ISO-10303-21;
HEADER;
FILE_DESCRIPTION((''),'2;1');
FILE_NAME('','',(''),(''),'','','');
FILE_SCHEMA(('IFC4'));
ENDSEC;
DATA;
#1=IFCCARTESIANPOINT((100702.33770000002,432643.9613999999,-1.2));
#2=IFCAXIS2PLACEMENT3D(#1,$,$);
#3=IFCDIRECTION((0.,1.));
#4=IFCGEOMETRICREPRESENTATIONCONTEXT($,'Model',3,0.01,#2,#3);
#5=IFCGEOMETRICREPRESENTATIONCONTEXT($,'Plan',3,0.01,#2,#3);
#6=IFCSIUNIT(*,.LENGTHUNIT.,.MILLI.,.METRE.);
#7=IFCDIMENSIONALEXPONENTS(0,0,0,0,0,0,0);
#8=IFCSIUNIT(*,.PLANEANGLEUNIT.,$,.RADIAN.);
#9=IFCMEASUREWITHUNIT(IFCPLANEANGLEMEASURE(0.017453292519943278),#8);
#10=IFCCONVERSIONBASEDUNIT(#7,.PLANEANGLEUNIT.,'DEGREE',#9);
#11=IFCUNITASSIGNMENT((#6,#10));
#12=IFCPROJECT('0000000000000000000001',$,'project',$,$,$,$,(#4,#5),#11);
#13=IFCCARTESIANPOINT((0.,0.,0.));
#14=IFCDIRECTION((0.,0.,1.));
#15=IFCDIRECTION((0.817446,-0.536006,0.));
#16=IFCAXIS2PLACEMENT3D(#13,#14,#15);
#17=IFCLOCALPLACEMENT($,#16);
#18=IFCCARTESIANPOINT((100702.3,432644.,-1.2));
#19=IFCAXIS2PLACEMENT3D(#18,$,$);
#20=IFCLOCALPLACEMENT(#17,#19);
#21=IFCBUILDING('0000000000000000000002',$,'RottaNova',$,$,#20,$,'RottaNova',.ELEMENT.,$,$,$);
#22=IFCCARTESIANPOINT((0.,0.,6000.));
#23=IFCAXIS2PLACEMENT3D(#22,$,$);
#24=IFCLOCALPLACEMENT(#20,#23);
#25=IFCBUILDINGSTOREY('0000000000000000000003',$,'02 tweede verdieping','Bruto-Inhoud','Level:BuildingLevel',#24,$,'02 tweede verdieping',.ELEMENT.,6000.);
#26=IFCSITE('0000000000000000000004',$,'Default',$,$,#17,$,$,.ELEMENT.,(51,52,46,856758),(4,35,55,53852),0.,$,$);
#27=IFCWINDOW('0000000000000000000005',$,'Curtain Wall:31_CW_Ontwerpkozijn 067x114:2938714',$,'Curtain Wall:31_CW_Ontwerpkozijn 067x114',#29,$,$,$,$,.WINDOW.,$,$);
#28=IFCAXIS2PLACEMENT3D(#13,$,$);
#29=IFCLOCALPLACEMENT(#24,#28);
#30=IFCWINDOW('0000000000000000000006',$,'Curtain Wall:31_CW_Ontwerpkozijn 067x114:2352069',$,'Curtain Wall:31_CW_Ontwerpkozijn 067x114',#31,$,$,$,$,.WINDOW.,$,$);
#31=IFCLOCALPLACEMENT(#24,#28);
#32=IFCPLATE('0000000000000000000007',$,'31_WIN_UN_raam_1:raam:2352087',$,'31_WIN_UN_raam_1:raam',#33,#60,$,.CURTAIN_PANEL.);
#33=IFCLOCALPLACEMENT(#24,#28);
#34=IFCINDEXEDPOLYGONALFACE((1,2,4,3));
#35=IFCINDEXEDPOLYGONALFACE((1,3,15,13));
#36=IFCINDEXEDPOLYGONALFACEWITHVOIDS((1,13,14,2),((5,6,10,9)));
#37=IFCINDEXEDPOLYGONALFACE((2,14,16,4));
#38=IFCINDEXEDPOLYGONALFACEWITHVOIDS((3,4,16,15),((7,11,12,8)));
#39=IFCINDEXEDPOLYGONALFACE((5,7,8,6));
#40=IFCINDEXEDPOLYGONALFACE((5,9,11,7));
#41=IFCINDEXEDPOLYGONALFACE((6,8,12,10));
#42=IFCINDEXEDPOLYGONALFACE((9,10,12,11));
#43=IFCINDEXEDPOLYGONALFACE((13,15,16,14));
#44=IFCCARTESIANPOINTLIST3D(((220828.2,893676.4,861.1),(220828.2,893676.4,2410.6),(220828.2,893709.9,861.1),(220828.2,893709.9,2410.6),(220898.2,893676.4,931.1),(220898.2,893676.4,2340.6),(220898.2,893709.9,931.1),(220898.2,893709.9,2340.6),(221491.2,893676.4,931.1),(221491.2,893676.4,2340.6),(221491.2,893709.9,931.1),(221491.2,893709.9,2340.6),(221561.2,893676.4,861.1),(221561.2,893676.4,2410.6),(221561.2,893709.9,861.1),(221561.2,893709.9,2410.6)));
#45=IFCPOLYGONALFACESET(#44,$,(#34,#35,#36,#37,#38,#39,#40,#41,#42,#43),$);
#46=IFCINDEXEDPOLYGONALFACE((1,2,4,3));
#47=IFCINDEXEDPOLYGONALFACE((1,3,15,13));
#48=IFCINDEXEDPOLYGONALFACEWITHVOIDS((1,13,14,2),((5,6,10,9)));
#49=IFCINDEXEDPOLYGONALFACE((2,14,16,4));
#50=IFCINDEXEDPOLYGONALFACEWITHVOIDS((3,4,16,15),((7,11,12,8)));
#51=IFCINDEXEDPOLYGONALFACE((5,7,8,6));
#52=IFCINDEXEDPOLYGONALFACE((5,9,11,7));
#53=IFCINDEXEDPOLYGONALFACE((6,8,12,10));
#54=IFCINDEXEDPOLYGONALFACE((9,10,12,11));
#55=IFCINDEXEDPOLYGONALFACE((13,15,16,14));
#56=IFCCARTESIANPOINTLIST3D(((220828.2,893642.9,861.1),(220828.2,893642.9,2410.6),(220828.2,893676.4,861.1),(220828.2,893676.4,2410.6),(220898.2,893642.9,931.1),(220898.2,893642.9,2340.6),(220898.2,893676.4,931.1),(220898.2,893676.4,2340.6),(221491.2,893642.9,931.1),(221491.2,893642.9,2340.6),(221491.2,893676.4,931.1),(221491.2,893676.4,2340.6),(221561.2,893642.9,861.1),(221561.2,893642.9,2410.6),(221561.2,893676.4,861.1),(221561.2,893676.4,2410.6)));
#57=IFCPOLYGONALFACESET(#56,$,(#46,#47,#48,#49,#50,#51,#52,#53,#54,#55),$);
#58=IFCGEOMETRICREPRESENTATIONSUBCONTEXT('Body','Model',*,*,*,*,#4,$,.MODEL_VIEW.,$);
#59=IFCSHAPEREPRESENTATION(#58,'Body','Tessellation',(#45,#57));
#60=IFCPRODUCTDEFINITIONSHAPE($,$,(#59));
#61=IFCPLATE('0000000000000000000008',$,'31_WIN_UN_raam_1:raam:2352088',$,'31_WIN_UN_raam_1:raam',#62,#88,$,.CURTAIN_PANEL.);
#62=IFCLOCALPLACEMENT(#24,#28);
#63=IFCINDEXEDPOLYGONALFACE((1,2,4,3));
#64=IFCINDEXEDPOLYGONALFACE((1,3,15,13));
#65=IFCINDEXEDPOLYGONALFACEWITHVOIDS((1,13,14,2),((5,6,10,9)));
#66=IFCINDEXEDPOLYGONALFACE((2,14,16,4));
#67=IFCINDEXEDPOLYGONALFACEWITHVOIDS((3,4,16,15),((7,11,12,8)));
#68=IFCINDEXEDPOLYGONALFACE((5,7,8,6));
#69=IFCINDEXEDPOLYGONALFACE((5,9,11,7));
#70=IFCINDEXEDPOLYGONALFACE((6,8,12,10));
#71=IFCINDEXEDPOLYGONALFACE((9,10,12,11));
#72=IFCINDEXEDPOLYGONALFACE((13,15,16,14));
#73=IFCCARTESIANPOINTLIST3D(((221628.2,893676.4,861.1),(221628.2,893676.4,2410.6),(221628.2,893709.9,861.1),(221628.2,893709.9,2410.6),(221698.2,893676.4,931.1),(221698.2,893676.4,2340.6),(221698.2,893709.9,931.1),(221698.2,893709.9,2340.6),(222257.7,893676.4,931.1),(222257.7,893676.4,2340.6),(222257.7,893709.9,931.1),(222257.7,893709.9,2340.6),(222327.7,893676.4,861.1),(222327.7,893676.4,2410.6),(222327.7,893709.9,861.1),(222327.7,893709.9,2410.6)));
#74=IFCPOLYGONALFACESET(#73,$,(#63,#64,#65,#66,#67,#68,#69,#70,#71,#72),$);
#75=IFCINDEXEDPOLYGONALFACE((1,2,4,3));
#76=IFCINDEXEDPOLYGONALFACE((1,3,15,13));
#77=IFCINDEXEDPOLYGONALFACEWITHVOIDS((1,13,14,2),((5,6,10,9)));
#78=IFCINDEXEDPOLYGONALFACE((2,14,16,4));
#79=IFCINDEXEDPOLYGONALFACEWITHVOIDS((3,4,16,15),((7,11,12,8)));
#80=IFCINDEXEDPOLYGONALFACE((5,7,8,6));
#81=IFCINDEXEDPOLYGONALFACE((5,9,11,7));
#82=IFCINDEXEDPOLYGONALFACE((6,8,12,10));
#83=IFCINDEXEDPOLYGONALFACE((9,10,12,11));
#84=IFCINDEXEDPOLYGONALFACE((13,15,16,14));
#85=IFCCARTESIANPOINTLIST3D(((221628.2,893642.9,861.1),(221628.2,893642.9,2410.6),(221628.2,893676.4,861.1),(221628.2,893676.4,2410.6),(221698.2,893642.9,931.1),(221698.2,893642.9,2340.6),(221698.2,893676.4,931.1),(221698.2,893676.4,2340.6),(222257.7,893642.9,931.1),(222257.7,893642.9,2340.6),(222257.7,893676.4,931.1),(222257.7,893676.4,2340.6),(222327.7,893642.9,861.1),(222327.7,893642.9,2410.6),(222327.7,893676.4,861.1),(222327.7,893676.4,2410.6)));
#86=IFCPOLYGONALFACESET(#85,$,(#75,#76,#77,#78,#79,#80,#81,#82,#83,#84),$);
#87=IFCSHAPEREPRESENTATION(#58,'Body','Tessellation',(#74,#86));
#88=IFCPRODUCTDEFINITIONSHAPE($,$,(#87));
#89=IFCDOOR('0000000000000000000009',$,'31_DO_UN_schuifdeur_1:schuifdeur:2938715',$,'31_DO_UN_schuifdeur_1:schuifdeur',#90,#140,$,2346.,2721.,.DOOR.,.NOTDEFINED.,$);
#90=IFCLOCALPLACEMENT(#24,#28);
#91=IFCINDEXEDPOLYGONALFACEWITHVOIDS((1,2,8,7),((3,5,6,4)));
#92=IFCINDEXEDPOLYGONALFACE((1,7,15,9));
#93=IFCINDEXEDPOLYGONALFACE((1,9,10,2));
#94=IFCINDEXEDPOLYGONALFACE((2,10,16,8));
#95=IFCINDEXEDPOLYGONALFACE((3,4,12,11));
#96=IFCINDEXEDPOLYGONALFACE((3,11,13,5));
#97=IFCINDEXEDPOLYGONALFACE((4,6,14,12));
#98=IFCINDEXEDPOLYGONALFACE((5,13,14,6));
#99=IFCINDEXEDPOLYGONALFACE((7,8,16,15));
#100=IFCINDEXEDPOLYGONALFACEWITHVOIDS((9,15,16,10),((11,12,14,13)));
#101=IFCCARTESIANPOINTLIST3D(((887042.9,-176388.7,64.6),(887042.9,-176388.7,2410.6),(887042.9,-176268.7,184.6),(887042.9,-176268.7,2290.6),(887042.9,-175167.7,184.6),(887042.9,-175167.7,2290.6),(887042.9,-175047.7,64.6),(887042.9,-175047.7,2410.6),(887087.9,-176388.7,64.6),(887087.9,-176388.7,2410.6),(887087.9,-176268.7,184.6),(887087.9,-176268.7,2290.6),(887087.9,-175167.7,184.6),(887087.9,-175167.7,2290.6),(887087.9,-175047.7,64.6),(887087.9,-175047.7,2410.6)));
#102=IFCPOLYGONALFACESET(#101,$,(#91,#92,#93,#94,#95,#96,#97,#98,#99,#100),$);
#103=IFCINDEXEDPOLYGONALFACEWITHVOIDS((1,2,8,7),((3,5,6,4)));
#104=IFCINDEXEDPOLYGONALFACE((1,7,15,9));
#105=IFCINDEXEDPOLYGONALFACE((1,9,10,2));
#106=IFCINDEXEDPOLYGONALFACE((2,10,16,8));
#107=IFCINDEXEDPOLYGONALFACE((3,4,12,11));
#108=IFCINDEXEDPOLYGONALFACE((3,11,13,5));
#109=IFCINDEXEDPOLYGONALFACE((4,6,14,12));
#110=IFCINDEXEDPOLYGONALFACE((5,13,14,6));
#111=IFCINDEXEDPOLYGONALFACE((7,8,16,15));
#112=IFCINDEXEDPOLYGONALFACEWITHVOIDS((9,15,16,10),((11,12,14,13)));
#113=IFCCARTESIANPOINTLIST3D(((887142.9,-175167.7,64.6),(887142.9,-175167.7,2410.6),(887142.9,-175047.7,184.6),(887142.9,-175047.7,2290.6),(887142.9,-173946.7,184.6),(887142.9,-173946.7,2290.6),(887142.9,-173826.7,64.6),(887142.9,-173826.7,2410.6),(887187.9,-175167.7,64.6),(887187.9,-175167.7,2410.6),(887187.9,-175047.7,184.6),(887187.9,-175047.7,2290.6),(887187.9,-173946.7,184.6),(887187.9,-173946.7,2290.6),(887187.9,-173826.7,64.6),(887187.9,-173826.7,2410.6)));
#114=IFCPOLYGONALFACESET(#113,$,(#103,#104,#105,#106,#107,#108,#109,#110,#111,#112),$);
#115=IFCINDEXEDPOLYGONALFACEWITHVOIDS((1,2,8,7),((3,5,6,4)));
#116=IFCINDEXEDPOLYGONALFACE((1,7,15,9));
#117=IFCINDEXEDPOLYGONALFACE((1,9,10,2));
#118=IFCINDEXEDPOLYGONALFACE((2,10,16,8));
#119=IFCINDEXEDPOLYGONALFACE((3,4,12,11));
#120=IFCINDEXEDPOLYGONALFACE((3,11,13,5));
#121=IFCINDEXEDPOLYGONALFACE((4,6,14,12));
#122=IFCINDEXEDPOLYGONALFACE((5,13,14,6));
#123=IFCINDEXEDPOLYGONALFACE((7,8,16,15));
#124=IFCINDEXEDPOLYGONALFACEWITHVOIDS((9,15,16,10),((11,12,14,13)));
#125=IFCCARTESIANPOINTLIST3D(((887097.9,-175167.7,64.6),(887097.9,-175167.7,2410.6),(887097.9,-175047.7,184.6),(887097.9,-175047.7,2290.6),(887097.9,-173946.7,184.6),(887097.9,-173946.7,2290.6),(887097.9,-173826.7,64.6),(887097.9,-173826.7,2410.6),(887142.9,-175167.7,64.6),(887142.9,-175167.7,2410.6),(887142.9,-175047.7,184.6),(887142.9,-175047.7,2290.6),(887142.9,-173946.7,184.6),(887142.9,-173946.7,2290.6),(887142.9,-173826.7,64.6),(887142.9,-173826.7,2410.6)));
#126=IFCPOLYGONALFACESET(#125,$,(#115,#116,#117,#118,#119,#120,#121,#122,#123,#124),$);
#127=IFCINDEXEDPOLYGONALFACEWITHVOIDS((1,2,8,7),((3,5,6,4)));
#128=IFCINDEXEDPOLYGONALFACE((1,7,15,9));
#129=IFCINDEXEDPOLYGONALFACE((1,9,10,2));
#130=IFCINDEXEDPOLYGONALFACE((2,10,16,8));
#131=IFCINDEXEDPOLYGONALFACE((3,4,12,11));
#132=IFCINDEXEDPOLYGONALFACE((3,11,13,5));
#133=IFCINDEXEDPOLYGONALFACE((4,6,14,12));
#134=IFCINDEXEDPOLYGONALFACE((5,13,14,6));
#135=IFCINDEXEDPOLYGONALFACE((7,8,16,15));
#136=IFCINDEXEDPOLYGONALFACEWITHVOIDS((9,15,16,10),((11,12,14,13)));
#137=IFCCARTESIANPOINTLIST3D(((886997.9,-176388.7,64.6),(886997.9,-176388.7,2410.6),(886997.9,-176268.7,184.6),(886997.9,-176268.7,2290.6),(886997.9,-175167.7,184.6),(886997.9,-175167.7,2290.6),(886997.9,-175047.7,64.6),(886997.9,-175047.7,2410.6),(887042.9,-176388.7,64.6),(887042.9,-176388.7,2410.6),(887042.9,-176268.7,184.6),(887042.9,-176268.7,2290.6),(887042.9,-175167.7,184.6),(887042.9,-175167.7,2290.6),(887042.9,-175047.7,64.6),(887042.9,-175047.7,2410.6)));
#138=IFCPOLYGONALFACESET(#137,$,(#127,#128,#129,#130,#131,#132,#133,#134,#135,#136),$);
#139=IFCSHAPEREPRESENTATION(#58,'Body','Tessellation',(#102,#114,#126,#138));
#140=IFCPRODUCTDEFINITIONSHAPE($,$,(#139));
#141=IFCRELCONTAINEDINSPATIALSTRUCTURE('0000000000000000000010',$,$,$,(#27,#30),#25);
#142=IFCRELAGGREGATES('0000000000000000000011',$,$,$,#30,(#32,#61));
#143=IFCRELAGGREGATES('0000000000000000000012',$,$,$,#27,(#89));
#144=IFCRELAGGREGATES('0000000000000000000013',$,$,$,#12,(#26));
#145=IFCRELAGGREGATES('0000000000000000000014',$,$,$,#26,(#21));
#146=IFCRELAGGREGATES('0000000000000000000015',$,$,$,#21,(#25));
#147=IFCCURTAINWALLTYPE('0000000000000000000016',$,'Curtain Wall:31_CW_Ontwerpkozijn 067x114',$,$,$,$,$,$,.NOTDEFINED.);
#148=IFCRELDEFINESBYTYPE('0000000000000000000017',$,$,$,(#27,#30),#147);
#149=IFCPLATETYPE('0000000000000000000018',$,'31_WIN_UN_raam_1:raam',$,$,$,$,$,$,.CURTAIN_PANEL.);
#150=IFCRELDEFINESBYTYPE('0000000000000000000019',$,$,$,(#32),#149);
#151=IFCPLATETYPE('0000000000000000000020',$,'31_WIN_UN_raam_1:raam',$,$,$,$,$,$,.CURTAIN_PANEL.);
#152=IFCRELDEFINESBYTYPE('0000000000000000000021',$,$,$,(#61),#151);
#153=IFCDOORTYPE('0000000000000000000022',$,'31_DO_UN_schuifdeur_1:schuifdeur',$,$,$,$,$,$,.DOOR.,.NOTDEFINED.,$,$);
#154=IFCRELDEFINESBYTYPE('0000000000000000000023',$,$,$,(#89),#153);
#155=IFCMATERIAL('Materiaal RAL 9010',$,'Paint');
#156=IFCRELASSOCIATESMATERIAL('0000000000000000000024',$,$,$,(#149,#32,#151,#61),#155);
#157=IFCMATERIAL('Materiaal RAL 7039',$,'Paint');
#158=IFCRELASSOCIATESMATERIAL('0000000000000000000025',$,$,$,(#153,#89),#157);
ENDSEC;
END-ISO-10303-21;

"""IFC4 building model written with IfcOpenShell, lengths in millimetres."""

from ifc_helpers import new_model, entity, si_unit, converted_unit, direction, frame, place, context, subcontext, project, spatial, indexed_curve, outline, extrude, source, transform, mapped, material, type_object, type_shapes, element, aggregate, save


model = new_model("IFC4")

# Units and contexts
model_context = context("Model", 3, precision=0.01, world=frame((100702.33770000002, 432643.9613999999, -1.2)), true_north=direction((0.0, 1.0)))
plan_context = context("Plan", 3, precision=0.01, world=frame((100702.33770000002, 432643.9613999999, -1.2)), true_north=direction((0.0, 1.0)))
body_context = subcontext(model_context, "Body", "Model", "MODEL_VIEW")
ifc_project = project(units=[si_unit("LENGTHUNIT", "METRE", prefix="MILLI"), converted_unit("PLANEANGLEUNIT", "DEGREE", entity("IfcPlaneAngleMeasure", 0.017453292519943278), si_unit("PLANEANGLEUNIT", "RADIAN"), dimensions=[0, 0, 0, 0, 0, 0, 0])], contexts=[model_context, plan_context])

# Site, building, storey
site_placement = place(None, frame((0.0, 0.0, 0.0), z_axis=(0.0, 0.0, 1.0), x_axis=(0.817446, -0.536006, 0.0)))
site = spatial("IfcSite", under=ifc_project, at=site_placement, Name="Default", CompositionType="ELEMENT", RefLatitude=(51, 52, 46, 856758), RefLongitude=(4, 35, 55, 53852), RefElevation=0.0)
building_placement = place(site_placement, frame((100702.3, 432644.0, -1.2)))
building = spatial("IfcBuilding", under=site, at=building_placement, Name="RottaNova", LongName="RottaNova", CompositionType="ELEMENT")
storey_placement = place(building_placement, frame((0.0, 0.0, 6000.0)))
storey = spatial("IfcBuildingStorey", under=building, at=storey_placement, Name="02 tweede verdieping", Description="Bruto-Inhoud", ObjectType="Level:BuildingLevel", LongName="02 tweede verdieping", CompositionType="ELEMENT", Elevation=6000.0)

# Window
curtain_wall_type = type_object("IfcCurtainWallType", Name="Curtain Wall:31_CW_Ontwerpkozijn 067x114", PredefinedType="NOTDEFINED")
window_1_placement = place(storey_placement, frame((0.0, 0.0, -6000.0)))
window_1 = element("IfcWindow", 1, at=window_1_placement, inside=storey, type_object=curtain_wall_type, Name="Curtain Wall:31_CW_Ontwerpkozijn 067x114:2938714", ObjectType="Curtain Wall:31_CW_Ontwerpkozijn 067x114", PredefinedType="WINDOW")
ifc_material_1 = material(Name="Materiaal RAL 7039", Category="Paint")

# Window, plates
window_2_placement = place(storey_placement, frame((0.0, 0.0, -6000.0)))
window_2 = element("IfcWindow", 2, at=window_2_placement, inside=storey, type_object=curtain_wall_type, Name="Curtain Wall:31_CW_Ontwerpkozijn 067x114:2352069", ObjectType="Curtain Wall:31_CW_Ontwerpkozijn 067x114", PredefinedType="WINDOW")
ifc_material_2 = material(Name="Materiaal RAL 9010", Category="Paint")
plate_type_1 = type_object("IfcPlateType", Name="31_WIN_UN_raam_1:raam", PredefinedType="CURTAIN_PANEL", material=ifc_material_2)
shared_shape_1 = source(frame((100702.3, 432644.0, -1.2)), body_context, "Body", "SweptSolid", [
    extrude(outline(indexed_curve([(-366.5, -774.8), (366.5, -774.8), (366.5, 774.8), (-366.5, 774.8), (-366.5, -774.8)], self_intersect=False), holes=[indexed_curve([(-296.5, 704.8), (296.5, 704.8), (296.5, -704.8), (-296.5, -704.8), (-296.5, 704.8)], self_intersect=False)]), frame((0.0, 58.5, 774.8), z_axis=(0.0, 1.0, 0.0), x_axis=(1.0, 0.0, 0.0)), (0.0, 0.0, 1.0), 33.5),
    extrude(outline(indexed_curve([(-366.5, -774.8), (366.5, -774.8), (366.5, 774.8), (-366.5, 774.8), (-366.5, -774.8)], self_intersect=False), holes=[indexed_curve([(-296.5, 704.7), (296.5, 704.7), (296.5, -704.8), (-296.5, -704.8), (-296.5, 704.7)], self_intersect=False)]), frame((0.0, 25.0, 774.8), z_axis=(0.0, 1.0, 0.0), x_axis=(1.0, 0.0, 0.0)), (0.0, 0.0, 1.0), 33.5),
])
type_shapes(plate_type_1, [shared_shape_1])
plate_1_placement = place(window_2_placement, frame((19790.0, 28330.0, 6863.5)))
plate_1 = element("IfcPlate", 3, at=plate_1_placement, type_object=plate_type_1, material=ifc_material_2, Name="31_WIN_UN_raam_1:raam:2352087", ObjectType="31_WIN_UN_raam_1:raam", PredefinedType="CURTAIN_PANEL", context=body_context, shape_type="MappedRepresentation", body=[
    mapped(shared_shape_1, transform((100702.3, 432644.0, -1.2), scale=1.0)),
])
plate_type_2 = type_object("IfcPlateType", Name="31_WIN_UN_raam_1:raam", PredefinedType="CURTAIN_PANEL", material=ifc_material_2)
shared_shape_2 = source(frame((100702.3, 432644.0, -1.2)), body_context, "Body", "SweptSolid", [
    extrude(outline(indexed_curve([(-349.7, -774.8), (349.7, -774.8), (349.7, 774.8), (-349.7, 774.8), (-349.7, -774.8)], self_intersect=False), holes=[indexed_curve([(-279.7, 704.8), (279.7, 704.8), (279.7, -704.8), (-279.7, -704.8), (-279.7, 704.8)], self_intersect=False)]), frame((0.0, 58.5, 774.8), z_axis=(0.0, 1.0, 0.0), x_axis=(1.0, 0.0, 0.0)), (0.0, 0.0, 1.0), 33.5),
    extrude(outline(indexed_curve([(-349.7, -774.8), (349.7, -774.8), (349.7, 774.8), (-349.7, 774.8), (-349.7, -774.8)], self_intersect=False), holes=[indexed_curve([(-279.7, 704.7), (279.7, 704.7), (279.7, -704.8), (-279.7, -704.8), (-279.7, 704.7)], self_intersect=False)]), frame((0.0, 25.0, 774.8), z_axis=(0.0, 1.0, 0.0), x_axis=(1.0, 0.0, 0.0)), (0.0, 0.0, 1.0), 33.5),
])
type_shapes(plate_type_2, [shared_shape_2])
plate_2_placement = place(window_2_placement, frame((20573.3, 28330.0, 6863.5)))
plate_2 = element("IfcPlate", 4, at=plate_2_placement, type_object=plate_type_2, material=ifc_material_2, Name="31_WIN_UN_raam_1:raam:2352088", ObjectType="31_WIN_UN_raam_1:raam", PredefinedType="CURTAIN_PANEL", context=body_context, shape_type="MappedRepresentation", body=[
    mapped(shared_shape_2, transform((100702.3, 432644.0, -1.2), scale=1.0)),
])
aggregate(window_2, [plate_1, plate_2])

# Door
door_type = type_object("IfcDoorType", Name="31_DO_UN_schuifdeur_1:schuifdeur", OperationType="NOTDEFINED", PredefinedType="DOOR", material=ifc_material_1)
shared_shape_3 = source(frame((100702.3, 432644.0, -1.2)), body_context, "Body", "SweptSolid", [
    extrude(outline(indexed_curve([(-670.5, -1173.0), (670.5, -1173.0), (670.5, 1173.0), (-670.5, 1173.0), (-670.5, -1173.0)], self_intersect=False), holes=[indexed_curve([(-550.5, -1053.0), (-550.5, 1053.0), (550.5, 1053.0), (550.5, -1053.0), (-550.5, -1053.0)], self_intersect=False)]), frame((610.5, 45.0, 1173.0), z_axis=(0.0, 1.0, 0.0), x_axis=(1.0, 0.0, 0.0)), (0.0, 0.0, 1.0), 45.0),
    extrude(outline(indexed_curve([(-670.5, -1173.0), (670.5, -1173.0), (670.5, 1173.0), (-670.5, 1173.0), (-670.5, -1173.0)], self_intersect=False), holes=[indexed_curve([(-550.5, -1053.0), (-550.5, 1053.0), (550.5, 1053.0), (550.5, -1053.0), (-550.5, -1053.0)], self_intersect=False)]), frame((-610.5, 145.0, 1173.0), z_axis=(0.0, 1.0, 0.0), x_axis=(1.0, 0.0, 0.0)), (0.0, 0.0, 1.0), 45.0),
    extrude(outline(indexed_curve([(-670.5, -1173.0), (670.5, -1173.0), (670.5, 1173.0), (-670.5, 1173.0), (-670.5, -1173.0)], self_intersect=False), holes=[indexed_curve([(-550.5, -1053.0), (-550.5, 1053.0), (550.5, 1053.0), (550.5, -1053.0), (-550.5, -1053.0)], self_intersect=False)]), frame((-610.5, 100.0, 1173.0), z_axis=(0.0, 1.0, 0.0), x_axis=(1.0, 0.0, 0.0)), (0.0, 0.0, 1.0), 45.0),
    extrude(outline(indexed_curve([(-670.5, -1173.0), (670.5, -1173.0), (670.5, 1173.0), (-670.5, 1173.0), (-670.5, -1173.0)], self_intersect=False), holes=[indexed_curve([(-550.5, -1053.0), (-550.5, 1053.0), (550.5, 1053.0), (550.5, -1053.0), (-550.5, -1053.0)], self_intersect=False)]), frame((610.5, 0.0, 1173.0), z_axis=(0.0, 1.0, 0.0), x_axis=(1.0, 0.0, 0.0)), (0.0, 0.0, 1.0), 45.0),
])
type_shapes(door_type, [shared_shape_3])
door_placement = place(window_1_placement, frame((21710.0, 26297.0, 6067.0), z_axis=(0.0, 0.0, 1.0), x_axis=(0.0, -1.0, 0.0)))
door = element("IfcDoor", 5, at=door_placement, type_object=door_type, material=ifc_material_1, Name="31_DO_UN_schuifdeur_1:schuifdeur:2938715", ObjectType="31_DO_UN_schuifdeur_1:schuifdeur", OperationType="NOTDEFINED", OverallHeight=2346.0, OverallWidth=2721.0, PredefinedType="DOOR", context=body_context, shape_type="MappedRepresentation", body=[
    mapped(shared_shape_3, transform((100702.3, 432644.0, -1.2), scale=1.0)),
])
aggregate(window_1, [door])

save(model, "model.ifc")
